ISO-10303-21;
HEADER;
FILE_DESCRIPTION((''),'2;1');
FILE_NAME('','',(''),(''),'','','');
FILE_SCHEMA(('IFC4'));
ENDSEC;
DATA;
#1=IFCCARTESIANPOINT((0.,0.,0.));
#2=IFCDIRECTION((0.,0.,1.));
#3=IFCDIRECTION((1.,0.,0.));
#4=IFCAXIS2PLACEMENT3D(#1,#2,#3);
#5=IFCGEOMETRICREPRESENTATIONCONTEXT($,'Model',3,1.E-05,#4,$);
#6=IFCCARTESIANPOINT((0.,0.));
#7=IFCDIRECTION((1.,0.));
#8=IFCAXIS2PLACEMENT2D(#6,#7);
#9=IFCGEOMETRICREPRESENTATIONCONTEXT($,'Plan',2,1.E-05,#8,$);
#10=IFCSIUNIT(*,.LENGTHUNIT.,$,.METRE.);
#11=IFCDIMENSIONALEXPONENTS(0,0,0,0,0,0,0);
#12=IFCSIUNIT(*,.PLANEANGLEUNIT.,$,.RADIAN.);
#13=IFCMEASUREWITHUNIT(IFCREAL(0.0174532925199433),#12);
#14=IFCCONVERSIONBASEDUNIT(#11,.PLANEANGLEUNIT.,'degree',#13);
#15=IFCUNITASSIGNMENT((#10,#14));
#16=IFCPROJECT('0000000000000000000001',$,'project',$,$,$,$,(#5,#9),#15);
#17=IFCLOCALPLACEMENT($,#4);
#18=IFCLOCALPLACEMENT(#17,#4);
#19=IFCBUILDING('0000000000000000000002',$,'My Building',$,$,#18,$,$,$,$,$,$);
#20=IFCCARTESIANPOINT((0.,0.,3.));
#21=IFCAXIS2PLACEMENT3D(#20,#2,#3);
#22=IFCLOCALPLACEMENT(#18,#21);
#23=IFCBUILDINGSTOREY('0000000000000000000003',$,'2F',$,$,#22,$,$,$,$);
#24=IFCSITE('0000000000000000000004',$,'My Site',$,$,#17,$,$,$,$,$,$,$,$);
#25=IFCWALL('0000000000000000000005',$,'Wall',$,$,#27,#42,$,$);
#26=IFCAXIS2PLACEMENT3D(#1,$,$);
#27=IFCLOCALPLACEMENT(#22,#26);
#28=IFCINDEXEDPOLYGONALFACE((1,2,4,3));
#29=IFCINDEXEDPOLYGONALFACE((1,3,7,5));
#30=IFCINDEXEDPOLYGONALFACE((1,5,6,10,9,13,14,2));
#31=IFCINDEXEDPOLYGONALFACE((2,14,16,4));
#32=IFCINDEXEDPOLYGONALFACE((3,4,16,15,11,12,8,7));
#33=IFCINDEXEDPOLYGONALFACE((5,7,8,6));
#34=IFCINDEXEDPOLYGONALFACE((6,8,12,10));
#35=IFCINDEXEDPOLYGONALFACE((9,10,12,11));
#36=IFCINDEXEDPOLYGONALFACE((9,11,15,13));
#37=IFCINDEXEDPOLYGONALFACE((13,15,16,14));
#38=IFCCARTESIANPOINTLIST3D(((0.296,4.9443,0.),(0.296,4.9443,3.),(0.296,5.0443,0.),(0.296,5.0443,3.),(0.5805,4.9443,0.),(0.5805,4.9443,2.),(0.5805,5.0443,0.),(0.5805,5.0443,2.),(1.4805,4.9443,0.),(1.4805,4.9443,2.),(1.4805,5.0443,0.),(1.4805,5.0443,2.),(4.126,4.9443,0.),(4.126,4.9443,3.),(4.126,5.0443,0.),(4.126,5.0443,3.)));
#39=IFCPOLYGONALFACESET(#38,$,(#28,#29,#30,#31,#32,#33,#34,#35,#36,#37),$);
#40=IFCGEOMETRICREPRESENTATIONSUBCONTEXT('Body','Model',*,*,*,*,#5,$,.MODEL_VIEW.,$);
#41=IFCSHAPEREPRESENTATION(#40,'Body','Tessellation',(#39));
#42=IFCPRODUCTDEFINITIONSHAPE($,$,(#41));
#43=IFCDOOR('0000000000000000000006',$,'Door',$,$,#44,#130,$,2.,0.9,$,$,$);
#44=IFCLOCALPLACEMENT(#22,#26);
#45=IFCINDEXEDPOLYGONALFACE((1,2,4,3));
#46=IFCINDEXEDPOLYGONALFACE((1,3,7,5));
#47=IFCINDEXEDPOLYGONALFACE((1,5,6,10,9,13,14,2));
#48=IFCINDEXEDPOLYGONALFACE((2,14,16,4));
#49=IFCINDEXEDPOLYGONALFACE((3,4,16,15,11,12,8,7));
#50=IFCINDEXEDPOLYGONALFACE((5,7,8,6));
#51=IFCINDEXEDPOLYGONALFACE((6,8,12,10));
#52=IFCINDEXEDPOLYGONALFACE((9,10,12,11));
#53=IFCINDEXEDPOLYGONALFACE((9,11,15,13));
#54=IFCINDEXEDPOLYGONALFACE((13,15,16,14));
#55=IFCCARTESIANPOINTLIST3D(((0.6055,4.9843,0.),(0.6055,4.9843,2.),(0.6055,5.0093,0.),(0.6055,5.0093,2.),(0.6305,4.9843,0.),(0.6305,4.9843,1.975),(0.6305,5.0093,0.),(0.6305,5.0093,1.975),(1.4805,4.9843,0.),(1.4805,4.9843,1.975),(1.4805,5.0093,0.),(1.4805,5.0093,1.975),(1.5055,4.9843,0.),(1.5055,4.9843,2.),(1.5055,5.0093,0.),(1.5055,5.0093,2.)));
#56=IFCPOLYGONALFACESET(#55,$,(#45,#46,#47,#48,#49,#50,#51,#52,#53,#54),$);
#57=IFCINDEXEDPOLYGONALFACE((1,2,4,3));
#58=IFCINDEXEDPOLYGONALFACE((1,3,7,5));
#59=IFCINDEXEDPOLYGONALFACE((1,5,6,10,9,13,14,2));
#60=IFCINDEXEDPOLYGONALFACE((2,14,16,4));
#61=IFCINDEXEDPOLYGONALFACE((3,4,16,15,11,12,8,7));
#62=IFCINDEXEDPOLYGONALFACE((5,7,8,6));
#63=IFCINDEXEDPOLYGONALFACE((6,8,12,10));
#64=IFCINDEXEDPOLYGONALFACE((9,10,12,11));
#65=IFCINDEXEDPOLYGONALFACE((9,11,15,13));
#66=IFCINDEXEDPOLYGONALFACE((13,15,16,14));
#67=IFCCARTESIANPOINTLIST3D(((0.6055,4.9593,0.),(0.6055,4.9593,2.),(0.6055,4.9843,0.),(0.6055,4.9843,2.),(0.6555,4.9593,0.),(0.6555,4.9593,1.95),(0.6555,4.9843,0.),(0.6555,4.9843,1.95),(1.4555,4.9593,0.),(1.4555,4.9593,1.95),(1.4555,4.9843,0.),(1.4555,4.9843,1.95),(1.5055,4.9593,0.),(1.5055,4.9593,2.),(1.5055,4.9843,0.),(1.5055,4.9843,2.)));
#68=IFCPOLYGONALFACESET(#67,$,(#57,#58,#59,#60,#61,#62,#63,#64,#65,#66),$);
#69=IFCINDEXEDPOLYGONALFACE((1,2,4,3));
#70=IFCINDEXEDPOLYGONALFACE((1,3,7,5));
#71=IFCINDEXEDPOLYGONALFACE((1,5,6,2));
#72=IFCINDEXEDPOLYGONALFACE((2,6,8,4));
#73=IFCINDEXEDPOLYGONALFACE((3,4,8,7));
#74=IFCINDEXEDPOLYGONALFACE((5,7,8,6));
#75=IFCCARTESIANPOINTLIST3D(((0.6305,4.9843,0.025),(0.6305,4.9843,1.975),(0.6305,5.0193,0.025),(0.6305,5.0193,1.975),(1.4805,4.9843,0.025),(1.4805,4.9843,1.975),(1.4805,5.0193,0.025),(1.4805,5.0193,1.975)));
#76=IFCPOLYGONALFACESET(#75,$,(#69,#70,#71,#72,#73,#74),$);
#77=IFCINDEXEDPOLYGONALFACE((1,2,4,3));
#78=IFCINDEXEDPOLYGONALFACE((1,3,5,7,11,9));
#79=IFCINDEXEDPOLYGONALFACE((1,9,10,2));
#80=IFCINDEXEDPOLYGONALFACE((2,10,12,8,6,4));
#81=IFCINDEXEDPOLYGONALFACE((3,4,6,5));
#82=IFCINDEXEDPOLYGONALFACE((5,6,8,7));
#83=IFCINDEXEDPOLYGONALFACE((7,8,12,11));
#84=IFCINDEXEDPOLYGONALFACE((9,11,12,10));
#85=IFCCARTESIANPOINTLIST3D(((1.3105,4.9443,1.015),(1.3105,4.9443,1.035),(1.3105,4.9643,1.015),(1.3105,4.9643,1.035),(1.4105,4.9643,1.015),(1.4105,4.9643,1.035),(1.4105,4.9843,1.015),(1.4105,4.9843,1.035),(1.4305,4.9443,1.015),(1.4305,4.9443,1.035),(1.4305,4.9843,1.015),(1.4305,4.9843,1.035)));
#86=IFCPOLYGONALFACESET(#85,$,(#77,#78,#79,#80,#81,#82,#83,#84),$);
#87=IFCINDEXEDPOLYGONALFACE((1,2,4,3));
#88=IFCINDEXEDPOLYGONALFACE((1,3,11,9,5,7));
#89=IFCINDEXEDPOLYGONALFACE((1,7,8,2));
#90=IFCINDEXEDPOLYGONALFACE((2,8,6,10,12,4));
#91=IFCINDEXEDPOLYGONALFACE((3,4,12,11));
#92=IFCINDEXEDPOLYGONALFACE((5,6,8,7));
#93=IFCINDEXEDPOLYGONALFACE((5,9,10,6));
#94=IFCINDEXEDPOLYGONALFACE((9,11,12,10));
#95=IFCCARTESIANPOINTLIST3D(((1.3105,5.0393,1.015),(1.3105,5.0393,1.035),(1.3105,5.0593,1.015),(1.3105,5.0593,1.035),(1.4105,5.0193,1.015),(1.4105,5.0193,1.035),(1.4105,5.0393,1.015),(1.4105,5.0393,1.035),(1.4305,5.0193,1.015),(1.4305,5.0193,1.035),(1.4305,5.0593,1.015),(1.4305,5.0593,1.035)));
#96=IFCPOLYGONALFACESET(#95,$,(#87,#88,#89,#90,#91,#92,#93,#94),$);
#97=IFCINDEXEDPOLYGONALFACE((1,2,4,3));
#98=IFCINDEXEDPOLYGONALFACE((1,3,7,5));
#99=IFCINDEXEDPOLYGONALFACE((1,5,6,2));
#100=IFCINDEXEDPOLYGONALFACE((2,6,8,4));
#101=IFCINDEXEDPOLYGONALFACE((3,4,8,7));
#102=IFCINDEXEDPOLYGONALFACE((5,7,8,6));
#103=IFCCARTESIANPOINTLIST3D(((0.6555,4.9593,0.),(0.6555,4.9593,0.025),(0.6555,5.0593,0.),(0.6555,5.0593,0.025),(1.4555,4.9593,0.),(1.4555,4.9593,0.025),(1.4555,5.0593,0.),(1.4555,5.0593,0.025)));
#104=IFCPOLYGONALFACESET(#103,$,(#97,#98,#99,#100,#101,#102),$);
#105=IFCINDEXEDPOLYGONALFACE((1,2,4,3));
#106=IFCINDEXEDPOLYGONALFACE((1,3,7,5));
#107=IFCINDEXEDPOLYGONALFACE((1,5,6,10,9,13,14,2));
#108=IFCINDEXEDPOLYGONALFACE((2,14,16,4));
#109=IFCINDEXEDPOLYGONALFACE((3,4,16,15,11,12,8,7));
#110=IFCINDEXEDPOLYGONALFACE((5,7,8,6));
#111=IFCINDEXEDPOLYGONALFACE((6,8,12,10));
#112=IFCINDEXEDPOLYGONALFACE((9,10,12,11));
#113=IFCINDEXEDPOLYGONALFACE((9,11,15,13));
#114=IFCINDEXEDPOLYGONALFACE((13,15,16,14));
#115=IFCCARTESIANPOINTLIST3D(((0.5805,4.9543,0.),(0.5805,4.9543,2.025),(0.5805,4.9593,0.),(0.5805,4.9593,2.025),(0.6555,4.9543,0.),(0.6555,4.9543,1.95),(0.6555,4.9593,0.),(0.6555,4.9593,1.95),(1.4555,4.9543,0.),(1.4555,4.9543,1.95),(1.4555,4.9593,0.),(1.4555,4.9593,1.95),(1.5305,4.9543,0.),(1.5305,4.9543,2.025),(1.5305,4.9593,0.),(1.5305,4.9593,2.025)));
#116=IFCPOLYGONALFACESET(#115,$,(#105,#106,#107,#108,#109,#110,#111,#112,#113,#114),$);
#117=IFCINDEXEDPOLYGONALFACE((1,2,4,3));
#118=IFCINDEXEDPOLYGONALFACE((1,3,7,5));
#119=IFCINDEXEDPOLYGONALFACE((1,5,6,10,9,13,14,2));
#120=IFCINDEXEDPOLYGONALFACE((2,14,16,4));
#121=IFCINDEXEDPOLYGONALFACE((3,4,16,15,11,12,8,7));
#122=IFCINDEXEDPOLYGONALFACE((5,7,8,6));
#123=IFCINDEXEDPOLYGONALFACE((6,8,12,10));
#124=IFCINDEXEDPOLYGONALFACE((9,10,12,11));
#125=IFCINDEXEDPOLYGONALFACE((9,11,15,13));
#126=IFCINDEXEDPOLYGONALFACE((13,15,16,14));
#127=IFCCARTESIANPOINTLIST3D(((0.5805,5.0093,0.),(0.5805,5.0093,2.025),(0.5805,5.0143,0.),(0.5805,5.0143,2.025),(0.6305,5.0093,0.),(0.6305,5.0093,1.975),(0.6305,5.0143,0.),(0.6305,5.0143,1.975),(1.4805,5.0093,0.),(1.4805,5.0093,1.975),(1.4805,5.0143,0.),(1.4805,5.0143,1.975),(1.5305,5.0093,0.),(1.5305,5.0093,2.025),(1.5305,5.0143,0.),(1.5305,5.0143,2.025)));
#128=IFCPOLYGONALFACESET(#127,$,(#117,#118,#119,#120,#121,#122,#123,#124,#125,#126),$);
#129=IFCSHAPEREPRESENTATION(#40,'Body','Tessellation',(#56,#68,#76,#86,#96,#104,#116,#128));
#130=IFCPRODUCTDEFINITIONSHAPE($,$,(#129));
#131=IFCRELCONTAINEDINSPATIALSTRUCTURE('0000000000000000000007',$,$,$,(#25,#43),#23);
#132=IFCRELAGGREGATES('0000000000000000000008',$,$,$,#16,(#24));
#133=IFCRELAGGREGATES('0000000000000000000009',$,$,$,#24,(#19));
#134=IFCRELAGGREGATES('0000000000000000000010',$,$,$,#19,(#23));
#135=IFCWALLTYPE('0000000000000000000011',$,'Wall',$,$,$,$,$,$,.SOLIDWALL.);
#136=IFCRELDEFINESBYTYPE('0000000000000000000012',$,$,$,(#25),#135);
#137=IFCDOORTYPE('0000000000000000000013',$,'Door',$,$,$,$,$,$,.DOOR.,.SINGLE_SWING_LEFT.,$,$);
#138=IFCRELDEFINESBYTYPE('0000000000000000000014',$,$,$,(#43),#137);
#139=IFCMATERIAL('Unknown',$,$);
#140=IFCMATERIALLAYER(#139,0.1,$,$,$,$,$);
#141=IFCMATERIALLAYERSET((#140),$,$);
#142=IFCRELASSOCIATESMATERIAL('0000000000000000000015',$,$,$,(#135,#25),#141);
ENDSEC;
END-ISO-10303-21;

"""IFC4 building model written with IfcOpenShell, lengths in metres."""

from ifc_helpers import new_model, entity, si_unit, converted_unit, frame, origin_with_axes, origin_2d_with_axis, place, context, subcontext, project, spatial, line, indexed_curve, outline, extrude, shape, source, transform, mapped, material, layer, layer_set, layer_usage, type_object, type_shapes, element, fill, save


model = new_model("IFC4")

# Units and contexts
model_context = context("Model", 3, precision=1e-05, world=origin_with_axes())
plan_context = context("Plan", 2, precision=1e-05, world=origin_2d_with_axis())
body_context_1 = subcontext(model_context, "Body", "Model", "MODEL_VIEW")
body_context_2 = subcontext(plan_context, "Body", "Plan", "PLAN_VIEW")
ifc_project = project(units=[si_unit("LENGTHUNIT", "METRE"), converted_unit("PLANEANGLEUNIT", "degree", entity("IfcReal", 0.0174532925199433), si_unit("PLANEANGLEUNIT", "RADIAN"), dimensions=[0, 0, 0, 0, 0, 0, 0])], contexts=[model_context, plan_context])

# Site, building, storey
site_placement = place(None, origin_with_axes())
site = spatial("IfcSite", under=ifc_project, at=site_placement, Name="My Site")
building_placement = place(site_placement, origin_with_axes())
building = spatial("IfcBuilding", under=site, at=building_placement, Name="My Building")
storey_placement = place(building_placement, frame((0.0, 0.0, 3.0), z_axis=(0.0, 0.0, 1.0), x_axis=(1.0, 0.0, 0.0)))
storey = spatial("IfcBuildingStorey", under=building, at=storey_placement, Name="2F")

# Shared definitions
ifc_material = material(Name="Unknown")

# Shared definitions
ifc_layer = layer(ifc_material, 0.1)
ifc_layer_set = layer_set([ifc_layer])
wall_type = type_object("IfcWallType", Name="Wall", PredefinedType="SOLIDWALL", material=ifc_layer_set)

# Wall, opening, door
ifc_layer_usage_1 = layer_usage(ifc_layer_set, "AXIS2", "POSITIVE", 0.0)
wall_1_placement = place(storey_placement, frame((4.126, 5.0443, 0.0), z_axis=(0.0, 0.0, 1.0), x_axis=(-1.0, -0.000001, 0.0)))
wall_1 = element("IfcWall", 1, at=wall_1_placement, inside=storey, type_object=wall_type, material=ifc_layer_usage_1, Name="Wall", context=body_context_1, shape_type="SweptSolid", body=[
    extrude(outline(indexed_curve([(0.0, 0.0), (0.0, 0.1), (3.83, 0.1), (3.83, 0.0)], segments=[line(1, 2, 3, 4, 1)])), origin_with_axes(), (0.0, 0.0, 1.0), 3.0),
])
shared_shape_1 = source(origin_with_axes(), body_context_1, "Body", "SweptSolid", [
    extrude(outline(indexed_curve([(0.0, 0.0), (0.9, 0.0), (0.9, 2.0), (0.0, 2.0)], segments=[line(1, 2, 3, 4, 1)])), frame((0.0, -0.6, 0.0), z_axis=(0.0, -1.0, 0.0), x_axis=(1.0, 0.0, 0.0)), (0.0, 0.0, -1.0), 1.2),
])
opening_1_placement = place(wall_1_placement, frame((2.6455, 0.0, 0.0), z_axis=(0.0, 0.0, 1.0), x_axis=(1.0, 0.0, 0.0)))
opening_1 = element("IfcOpeningElement", 2, at=opening_1_placement, cuts=wall_1, PredefinedType="OPENING", context=body_context_1, shape_type="MappedRepresentation", body=[
    mapped(shared_shape_1, transform((0.0, 0.0, 0.0), x_axis=(1.0, 0.0, 0.0), y_axis=(0.0, 1.0, 0.0), z_axis=(0.0, 0.0, 1.0), scale=1.0)),
])
door_type_1 = type_object("IfcDoorType", Name="Door", OperationType="SINGLE_SWING_LEFT", PredefinedType="DOOR")
shared_shape_2 = source(origin_with_axes(), body_context_1, "Body", "SweptSolid", [
    extrude(outline(indexed_curve([(0.0, 0.0), (0.0, 2.0), (0.9, 2.0), (0.9, 0.0), (0.875, 0.0), (0.875, 1.975), (0.025, 1.975), (0.025, 0.0)], segments=[line(1, 2, 3, 4, 5, 6, 7, 8, 1)])), frame((0.0, 0.025, 0.0), z_axis=(0.0, -1.0, 0.0), x_axis=(1.0, 0.0, 0.0)), (0.0, 0.0, -1.0), 0.025),
    extrude(outline(indexed_curve([(0.0, 0.0), (0.0, 2.0), (0.9, 2.0), (0.9, 0.0), (0.85, 0.0), (0.85, 1.95), (0.05, 1.95), (0.05, 0.0)], segments=[line(1, 2, 3, 4, 5, 6, 7, 8, 1)])), frame((0.0, 0.0, 0.0), z_axis=(0.0, -1.0, 0.0), x_axis=(1.0, 0.0, 0.0)), (0.0, 0.0, -1.0), 0.025),
    extrude(outline(indexed_curve([(0.0, 0.0), (0.85, 0.0), (0.85, 0.035), (0.0, 0.035)], segments=[line(1, 2, 3, 4, 1)])), frame((0.025, 0.025, 0.025), z_axis=(0.0, 0.0, 1.0), x_axis=(1.0, 0.0, 0.0)), (0.0, 0.0, 1.0), 1.95),
    extrude(outline(indexed_curve([(0.0, 0.0), (0.0, -0.04), (-0.12, -0.04), (-0.12, -0.02), (-0.02, -0.02), (-0.02, 0.0)], segments=[line(1, 2, 3, 4, 5, 6, 1)])), frame((0.825, 0.025, 1.015), z_axis=(0.0, 0.0, 1.0), x_axis=(1.0, 0.0, 0.0)), (0.0, 0.0, 1.0), 0.02),
    extrude(outline(indexed_curve([(0.0, 0.0), (0.0, 0.04), (-0.12, 0.04), (-0.12, 0.02), (-0.02, 0.02), (-0.02, 0.0)], segments=[line(1, 2, 3, 4, 5, 6, 1)])), frame((0.825, 0.06, 1.015), z_axis=(0.0, 0.0, 1.0), x_axis=(1.0, 0.0, 0.0)), (0.0, 0.0, 1.0), 0.02),
    extrude(outline(indexed_curve([(0.0, 0.0), (0.8, 0.0), (0.8, 0.1), (0.0, 0.1)], segments=[line(1, 2, 3, 4, 1)])), frame((0.05, 0.0, 0.0), z_axis=(0.0, 0.0, 1.0), x_axis=(1.0, 0.0, 0.0)), (0.0, 0.0, 1.0), 0.025),
    extrude(outline(indexed_curve([(0.0, 0.0), (0.0, 2.025), (0.95, 2.025), (0.95, 0.0), (0.875, 0.0), (0.875, 1.95), (0.075, 1.95), (0.075, 0.0)], segments=[line(1, 2, 3, 4, 5, 6, 7, 8, 1)])), frame((-0.025, -0.005, 0.0), z_axis=(0.0, -1.0, 0.0), x_axis=(1.0, 0.0, 0.0)), (0.0, 0.0, -1.0), 0.005),
    extrude(outline(indexed_curve([(0.0, 0.0), (0.0, 2.025), (0.95, 2.025), (0.95, 0.0), (0.9, 0.0), (0.9, 1.975), (0.05, 1.975), (0.05, 0.0)], segments=[line(1, 2, 3, 4, 5, 6, 7, 8, 1)])), frame((-0.025, 0.05, 0.0), z_axis=(0.0, -1.0, 0.0), x_axis=(1.0, 0.0, 0.0)), (0.0, 0.0, -1.0), 0.005),
])
shared_shape_3 = source(origin_with_axes(), body_context_2, "Body", "Curve2D", [
    entity("IfcIndexedPolyCurve", entity("IfcCartesianPointList2D", [[0.0, 0.0], [0.0, 0.05], [0.025, 0.05], [0.025, 0.025], [0.05, 0.025], [0.05, 0.0]]), [entity("IfcLineIndex", [1, 2, 3, 4, 5, 6, 1])]),
    entity("IfcIndexedPolyCurve", entity("IfcCartesianPointList2D", [[0.9, 0.0], [0.9, 0.05], [0.875, 0.05], [0.875, 0.025], [0.85, 0.025], [0.85, 0.0]]), [entity("IfcLineIndex", [1, 2, 3, 4, 5, 6, 1])]),
    entity("IfcTrimmedCurve", entity("IfcEllipse", entity("IfcAxis2Placement2D", entity("IfcCartesianPoint", [0.06, 0.05]), entity("IfcDirection", [1.0, 0.0])), 0.815, 0.85), [entity("IfcCartesianPoint", [0.875, 0.05])], [entity("IfcCartesianPoint", [0.06, 0.9])], True, "CARTESIAN"),
    entity("IfcIndexedPolyCurve", entity("IfcCartesianPointList2D", [[0.025, 0.05], [0.06, 0.05], [0.06, 0.9], [0.025, 0.9]]), [entity("IfcLineIndex", [1, 2, 3, 4, 1])]),
])
type_shapes(door_type_1, [shared_shape_2, shared_shape_3])
door_1_placement = place(opening_1_placement, frame((0.875, 0.085, 0.0), z_axis=(0.0, 0.0, 1.0), x_axis=(-1.0, 0.0, 0.0)))
door_1 = element("IfcDoor", 3, at=door_1_placement, inside=storey, type_object=door_type_1, Name="Door", OverallHeight=2.0, OverallWidth=0.9, shapes=[
    shape(body_context_1, "Body", "MappedRepresentation", [mapped(shared_shape_2, transform((0.0, 0.0, 0.0), x_axis=(1.0, 0.0, 0.0), y_axis=(0.0, 1.0, 0.0), z_axis=(0.0, 0.0, 1.0), scale=1.0))]),
    shape(body_context_2, "Body", "MappedRepresentation", [mapped(shared_shape_3, transform((0.0, 0.0, 0.0), x_axis=(1.0, 0.0, 0.0), y_axis=(0.0, 1.0, 0.0), z_axis=(0.0, 0.0, 1.0), scale=1.0))]),
])
fill(opening_1, door_1)

save(model, "model.ifc")
